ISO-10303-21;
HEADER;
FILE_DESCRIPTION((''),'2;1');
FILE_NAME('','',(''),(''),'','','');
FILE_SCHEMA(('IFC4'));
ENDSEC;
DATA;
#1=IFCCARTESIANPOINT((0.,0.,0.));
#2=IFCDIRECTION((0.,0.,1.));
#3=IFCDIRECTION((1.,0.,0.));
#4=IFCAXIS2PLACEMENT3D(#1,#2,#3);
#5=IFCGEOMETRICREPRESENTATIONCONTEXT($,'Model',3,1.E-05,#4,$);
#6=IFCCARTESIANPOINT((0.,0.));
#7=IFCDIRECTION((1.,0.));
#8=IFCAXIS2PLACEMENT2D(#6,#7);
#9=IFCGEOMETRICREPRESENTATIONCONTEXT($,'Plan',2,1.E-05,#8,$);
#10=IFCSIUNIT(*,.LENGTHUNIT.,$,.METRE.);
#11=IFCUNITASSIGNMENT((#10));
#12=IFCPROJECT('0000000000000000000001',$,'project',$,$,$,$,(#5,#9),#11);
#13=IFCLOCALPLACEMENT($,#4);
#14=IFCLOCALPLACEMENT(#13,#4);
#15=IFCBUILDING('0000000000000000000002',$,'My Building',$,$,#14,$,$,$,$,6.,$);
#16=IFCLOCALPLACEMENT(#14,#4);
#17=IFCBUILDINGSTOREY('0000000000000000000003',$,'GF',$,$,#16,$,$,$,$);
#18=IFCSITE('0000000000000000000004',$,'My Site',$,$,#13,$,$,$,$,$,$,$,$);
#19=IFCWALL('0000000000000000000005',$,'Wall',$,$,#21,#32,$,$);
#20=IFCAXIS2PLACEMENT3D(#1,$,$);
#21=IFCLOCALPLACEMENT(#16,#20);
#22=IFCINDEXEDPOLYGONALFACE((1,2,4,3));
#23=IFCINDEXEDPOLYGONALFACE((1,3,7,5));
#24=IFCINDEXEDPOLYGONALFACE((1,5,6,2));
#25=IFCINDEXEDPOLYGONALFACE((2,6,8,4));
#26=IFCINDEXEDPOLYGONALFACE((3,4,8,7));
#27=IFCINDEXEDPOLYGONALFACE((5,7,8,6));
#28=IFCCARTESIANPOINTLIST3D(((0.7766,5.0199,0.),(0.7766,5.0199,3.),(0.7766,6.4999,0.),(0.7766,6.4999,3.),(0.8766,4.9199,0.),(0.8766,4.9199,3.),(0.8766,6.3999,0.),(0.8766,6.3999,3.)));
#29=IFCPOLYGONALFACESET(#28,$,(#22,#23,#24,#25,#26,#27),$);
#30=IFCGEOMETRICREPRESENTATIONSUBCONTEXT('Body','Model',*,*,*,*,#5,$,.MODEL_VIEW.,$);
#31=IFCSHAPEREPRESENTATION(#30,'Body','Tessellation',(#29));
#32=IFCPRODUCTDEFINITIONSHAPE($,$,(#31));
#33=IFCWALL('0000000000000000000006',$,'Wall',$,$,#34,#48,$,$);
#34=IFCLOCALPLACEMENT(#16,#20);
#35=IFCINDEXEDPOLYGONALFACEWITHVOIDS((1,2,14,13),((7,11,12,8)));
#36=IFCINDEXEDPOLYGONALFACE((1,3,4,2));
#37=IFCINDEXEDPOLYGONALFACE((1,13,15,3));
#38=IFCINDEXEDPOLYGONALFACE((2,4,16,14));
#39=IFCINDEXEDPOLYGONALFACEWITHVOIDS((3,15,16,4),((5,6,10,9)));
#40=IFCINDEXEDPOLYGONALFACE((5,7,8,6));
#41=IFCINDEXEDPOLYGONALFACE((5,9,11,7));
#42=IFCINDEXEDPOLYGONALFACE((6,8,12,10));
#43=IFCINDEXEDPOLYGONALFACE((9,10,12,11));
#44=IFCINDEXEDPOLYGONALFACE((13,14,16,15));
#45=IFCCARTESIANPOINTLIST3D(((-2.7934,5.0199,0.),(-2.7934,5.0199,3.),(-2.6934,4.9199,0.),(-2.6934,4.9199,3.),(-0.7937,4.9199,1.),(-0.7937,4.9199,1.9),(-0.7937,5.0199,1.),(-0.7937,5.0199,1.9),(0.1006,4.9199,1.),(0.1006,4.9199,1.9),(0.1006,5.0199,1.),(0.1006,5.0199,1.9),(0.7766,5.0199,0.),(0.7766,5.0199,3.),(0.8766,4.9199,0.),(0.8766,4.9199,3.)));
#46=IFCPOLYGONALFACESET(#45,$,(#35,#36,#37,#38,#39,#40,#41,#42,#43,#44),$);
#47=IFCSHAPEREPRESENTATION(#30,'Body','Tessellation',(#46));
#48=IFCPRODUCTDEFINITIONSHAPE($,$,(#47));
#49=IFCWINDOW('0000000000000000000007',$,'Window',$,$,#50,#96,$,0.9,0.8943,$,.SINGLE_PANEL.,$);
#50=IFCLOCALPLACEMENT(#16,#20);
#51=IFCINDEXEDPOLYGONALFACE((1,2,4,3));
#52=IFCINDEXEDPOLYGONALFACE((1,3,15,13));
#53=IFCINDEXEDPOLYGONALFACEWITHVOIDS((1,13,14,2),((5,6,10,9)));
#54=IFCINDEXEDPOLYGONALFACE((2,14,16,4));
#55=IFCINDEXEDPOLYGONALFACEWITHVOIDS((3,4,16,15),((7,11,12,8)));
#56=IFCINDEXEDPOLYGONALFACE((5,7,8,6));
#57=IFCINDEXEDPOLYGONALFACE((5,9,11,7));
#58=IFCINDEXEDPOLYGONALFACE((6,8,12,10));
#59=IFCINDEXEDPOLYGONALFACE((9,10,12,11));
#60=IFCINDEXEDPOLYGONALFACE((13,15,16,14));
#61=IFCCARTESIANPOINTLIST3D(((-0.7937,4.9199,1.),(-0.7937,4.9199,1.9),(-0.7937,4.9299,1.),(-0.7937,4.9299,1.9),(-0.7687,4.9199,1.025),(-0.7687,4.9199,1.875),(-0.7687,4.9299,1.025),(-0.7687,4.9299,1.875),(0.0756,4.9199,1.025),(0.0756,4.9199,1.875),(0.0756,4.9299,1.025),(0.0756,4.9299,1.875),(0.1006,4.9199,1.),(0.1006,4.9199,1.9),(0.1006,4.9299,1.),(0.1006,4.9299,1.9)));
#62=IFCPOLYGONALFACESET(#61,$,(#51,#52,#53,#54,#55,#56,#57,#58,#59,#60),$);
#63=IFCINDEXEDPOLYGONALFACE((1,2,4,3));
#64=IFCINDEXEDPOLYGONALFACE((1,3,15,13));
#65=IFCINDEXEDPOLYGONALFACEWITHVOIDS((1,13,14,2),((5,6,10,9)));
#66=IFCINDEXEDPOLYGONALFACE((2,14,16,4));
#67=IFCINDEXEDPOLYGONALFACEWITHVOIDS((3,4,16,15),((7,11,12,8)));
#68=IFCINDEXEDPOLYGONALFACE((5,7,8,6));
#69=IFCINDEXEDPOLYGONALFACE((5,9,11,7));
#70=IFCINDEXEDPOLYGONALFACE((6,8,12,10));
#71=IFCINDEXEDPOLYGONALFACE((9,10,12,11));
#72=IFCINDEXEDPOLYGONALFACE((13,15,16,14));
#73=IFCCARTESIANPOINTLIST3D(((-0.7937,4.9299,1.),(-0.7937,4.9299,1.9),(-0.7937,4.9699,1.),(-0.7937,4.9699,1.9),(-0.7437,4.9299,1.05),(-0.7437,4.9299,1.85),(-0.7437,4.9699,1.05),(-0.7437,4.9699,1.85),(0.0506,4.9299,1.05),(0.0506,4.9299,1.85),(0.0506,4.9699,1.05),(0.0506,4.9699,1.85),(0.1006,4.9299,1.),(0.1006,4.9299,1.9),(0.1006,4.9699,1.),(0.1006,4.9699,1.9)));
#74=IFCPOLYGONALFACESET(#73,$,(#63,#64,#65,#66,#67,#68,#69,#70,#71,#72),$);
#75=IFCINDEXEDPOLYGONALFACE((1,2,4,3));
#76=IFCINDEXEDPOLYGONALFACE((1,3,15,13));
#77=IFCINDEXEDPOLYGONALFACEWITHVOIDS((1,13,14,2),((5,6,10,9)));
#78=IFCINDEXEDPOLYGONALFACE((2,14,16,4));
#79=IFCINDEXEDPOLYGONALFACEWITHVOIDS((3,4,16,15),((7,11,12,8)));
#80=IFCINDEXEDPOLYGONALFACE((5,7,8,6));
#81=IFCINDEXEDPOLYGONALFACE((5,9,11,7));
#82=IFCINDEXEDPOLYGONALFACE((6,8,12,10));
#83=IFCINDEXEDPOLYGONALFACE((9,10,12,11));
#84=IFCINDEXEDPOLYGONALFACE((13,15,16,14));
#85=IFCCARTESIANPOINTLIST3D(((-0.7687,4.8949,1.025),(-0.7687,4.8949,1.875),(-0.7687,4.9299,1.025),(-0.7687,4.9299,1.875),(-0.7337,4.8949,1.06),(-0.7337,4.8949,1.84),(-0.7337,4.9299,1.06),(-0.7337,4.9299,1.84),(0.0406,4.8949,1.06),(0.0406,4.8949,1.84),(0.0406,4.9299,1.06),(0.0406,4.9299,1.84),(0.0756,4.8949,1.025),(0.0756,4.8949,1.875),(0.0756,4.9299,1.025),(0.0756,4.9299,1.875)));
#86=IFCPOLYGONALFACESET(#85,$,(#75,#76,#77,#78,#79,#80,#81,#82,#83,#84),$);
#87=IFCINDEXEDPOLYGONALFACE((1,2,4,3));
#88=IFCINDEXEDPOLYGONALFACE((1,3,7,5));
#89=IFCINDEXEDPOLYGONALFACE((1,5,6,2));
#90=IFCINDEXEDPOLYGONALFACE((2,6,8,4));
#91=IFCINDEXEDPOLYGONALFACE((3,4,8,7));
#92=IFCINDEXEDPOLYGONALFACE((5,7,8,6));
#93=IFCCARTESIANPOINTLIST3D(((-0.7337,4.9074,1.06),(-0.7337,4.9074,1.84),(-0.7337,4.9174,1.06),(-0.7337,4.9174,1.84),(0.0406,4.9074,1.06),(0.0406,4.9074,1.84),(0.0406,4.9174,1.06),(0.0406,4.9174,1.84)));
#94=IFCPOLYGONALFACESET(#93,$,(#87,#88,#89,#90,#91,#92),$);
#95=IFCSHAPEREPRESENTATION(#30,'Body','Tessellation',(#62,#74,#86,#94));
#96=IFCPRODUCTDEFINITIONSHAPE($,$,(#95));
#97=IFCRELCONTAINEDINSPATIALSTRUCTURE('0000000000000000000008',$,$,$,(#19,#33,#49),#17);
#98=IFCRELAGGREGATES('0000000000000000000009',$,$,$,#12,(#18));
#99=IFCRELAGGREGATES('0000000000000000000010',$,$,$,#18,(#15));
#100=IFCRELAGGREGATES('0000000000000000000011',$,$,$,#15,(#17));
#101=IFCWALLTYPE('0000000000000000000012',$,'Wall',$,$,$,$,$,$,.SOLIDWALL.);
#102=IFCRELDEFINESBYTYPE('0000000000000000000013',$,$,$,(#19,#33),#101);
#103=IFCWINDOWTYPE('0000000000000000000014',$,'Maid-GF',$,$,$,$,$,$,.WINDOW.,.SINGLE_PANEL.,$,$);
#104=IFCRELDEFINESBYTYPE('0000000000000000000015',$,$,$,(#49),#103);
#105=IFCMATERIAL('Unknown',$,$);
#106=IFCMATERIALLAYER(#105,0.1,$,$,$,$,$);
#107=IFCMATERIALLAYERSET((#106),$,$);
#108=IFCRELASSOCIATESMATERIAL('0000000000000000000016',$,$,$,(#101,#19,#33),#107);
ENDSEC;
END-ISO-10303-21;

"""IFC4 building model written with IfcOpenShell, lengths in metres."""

from ifc_helpers import new_model, entity, si_unit, frame, origin_with_axes, origin_2d_with_axis, place, context, subcontext, project, spatial, line, indexed_curve, outline, extrude, shape, source, transform, mapped, material, layer, layer_set, layer_usage, type_object, type_shapes, element, fill, save


model = new_model("IFC4")

# Units and contexts
model_context = context("Model", 3, precision=1e-05, world=origin_with_axes())
plan_context = context("Plan", 2, precision=1e-05, world=origin_2d_with_axis())
body_context_1 = subcontext(model_context, "Body", "Model", "MODEL_VIEW")
body_context_2 = subcontext(plan_context, "Body", "Plan", "PLAN_VIEW")
ifc_project = project(units=[si_unit("LENGTHUNIT", "METRE")], contexts=[model_context, plan_context])

# Site, building, storey
site_placement = place(None, origin_with_axes())
site = spatial("IfcSite", under=ifc_project, at=site_placement, Name="My Site")
building_placement = place(site_placement, origin_with_axes())
building = spatial("IfcBuilding", under=site, at=building_placement, Name="My Building", ElevationOfTerrain=6.0)
storey_placement = place(building_placement, origin_with_axes())
storey = spatial("IfcBuildingStorey", under=building, at=storey_placement, Name="GF")

# Wall
ifc_material_1 = material(Name="Unknown")
ifc_layer = layer(ifc_material_1, 0.1)
ifc_layer_set = layer_set([ifc_layer])
wall_type = type_object("IfcWallType", Name="Wall", PredefinedType="SOLIDWALL", material=ifc_layer_set)
ifc_layer_usage_1 = layer_usage(ifc_layer_set, "AXIS2", "POSITIVE", 0.0)
wall_1_placement = place(storey_placement, frame((0.7766, 6.4999, 0.0), z_axis=(0.0, 0.0, 1.0), x_axis=(0.0, -1.0, 0.0)))
element("IfcWall", 1, at=wall_1_placement, inside=storey, type_object=wall_type, material=ifc_layer_usage_1, Name="Wall", context=body_context_1, shape_type="SweptSolid", body=[
    extrude(outline(indexed_curve([(0.0, 0.0), (0.1, 0.1), (1.58, 0.1), (1.48, 0.0)], segments=[line(1, 2, 3, 4, 1)])), origin_with_axes(), (0.0, 0.0, 1.0), 3.0),
])

# Wall, opening, window
ifc_layer_usage_2 = layer_usage(ifc_layer_set, "AXIS2", "POSITIVE", 0.0)
wall_2_placement = place(storey_placement, frame((0.7766, 5.0199, 0.0), z_axis=(0.0, 0.0, 1.0), x_axis=(-1.0, 0.0, 0.0)))
wall_2 = element("IfcWall", 2, at=wall_2_placement, inside=storey, type_object=wall_type, material=ifc_layer_usage_2, Name="Wall", context=body_context_1, shape_type="SweptSolid", body=[
    extrude(outline(indexed_curve([(0.0, 0.0), (-0.1, 0.1), (3.47, 0.1), (3.57, 0.0)], segments=[line(1, 2, 3, 4, 1)])), origin_with_axes(), (0.0, 0.0, 1.0), 3.0),
])
shared_shape_1 = source(origin_with_axes(), body_context_1, "Body", "SweptSolid", [
    extrude(outline(indexed_curve([(0.0, 0.0), (0.8943, 0.0), (0.8943, 0.9), (0.0, 0.9)], segments=[line(1, 2, 3, 4, 1)])), frame((0.0, -0.6, 0.0), z_axis=(0.0, -1.0, 0.0), x_axis=(1.0, 0.0, 0.0)), (0.0, 0.0, -1.0), 1.2),
])
opening_1_placement = place(wall_2_placement, frame((0.676, 0.0, 1.0), z_axis=(0.0, 0.0, 1.0), x_axis=(1.0, 0.0, 0.0)))
opening_1 = element("IfcOpeningElement", 3, at=opening_1_placement, cuts=wall_2, PredefinedType="OPENING", context=body_context_1, shape_type="MappedRepresentation", body=[
    mapped(shared_shape_1, transform((0.0, 0.0, 0.0), x_axis=(1.0, 0.0, 0.0), y_axis=(0.0, 1.0, 0.0), z_axis=(0.0, 0.0, 1.0), scale=1.0)),
])
window_type_1 = type_object("IfcWindowType", Name="Maid-GF", PartitioningType="SINGLE_PANEL", PredefinedType="WINDOW")
shared_shape_2 = source(origin_with_axes(), body_context_1, "Body", "SweptSolid", [
    extrude(outline(indexed_curve([(0.0, 0.0), (0.8943, 0.0), (0.8943, 0.9), (0.0, 0.9)], segments=[line(1, 2, 3, 4, 1)]), holes=[indexed_curve([(0.025, 0.025), (0.8693, 0.025), (0.8693, 0.875), (0.025, 0.875)], segments=[line(1, 2, 3, 4, 1)])]), frame((0.0, 0.09, 0.0), z_axis=(0.0, -1.0, 0.0), x_axis=(1.0, 0.0, 0.0)), (0.0, 0.0, -1.0), 0.01),
    extrude(outline(indexed_curve([(0.0, 0.0), (0.8943, 0.0), (0.8943, 0.9), (0.0, 0.9)], segments=[line(1, 2, 3, 4, 1)]), holes=[indexed_curve([(0.05, 0.05), (0.8443, 0.05), (0.8443, 0.85), (0.05, 0.85)], segments=[line(1, 2, 3, 4, 1)])]), frame((0.0, 0.05, 0.0), z_axis=(0.0, -1.0, 0.0), x_axis=(1.0, 0.0, 0.0)), (0.0, 0.0, -1.0), 0.04),
    extrude(outline(indexed_curve([(0.0, 0.0), (0.8443, 0.0), (0.8443, 0.85), (0.0, 0.85)], segments=[line(1, 2, 3, 4, 1)]), holes=[indexed_curve([(0.035, 0.035), (0.8093, 0.035), (0.8093, 0.815), (0.035, 0.815)], segments=[line(1, 2, 3, 4, 1)])]), frame((0.025, 0.09, 0.025), z_axis=(0.0, -1.0, 0.0), x_axis=(1.0, 0.0, 0.0)), (0.0, 0.0, -1.0), 0.035),
    extrude(outline(indexed_curve([(0.035, 0.035), (0.8093, 0.035), (0.8093, 0.815), (0.035, 0.815)], segments=[line(1, 2, 3, 4, 1)])), frame((0.025, 0.1025, 0.025), z_axis=(0.0, -1.0, 0.0), x_axis=(1.0, 0.0, 0.0)), (0.0, 0.0, -1.0), 0.01),
])
shared_shape_3 = source(origin_with_axes(), body_context_2, "Body", "Curve2D", [
    entity("IfcIndexedPolyCurve", entity("IfcCartesianPointList2D", [[0.05, 0.05], [0.8443, 0.05]])),
    entity("IfcIndexedPolyCurve", entity("IfcCartesianPointList2D", [[0.0, 0.1], [0.025, 0.1], [0.025, 0.09], [0.05, 0.09], [0.05, 0.05], [0.0, 0.05]]), [entity("IfcLineIndex", [1, 2, 3, 4, 5, 6, 1])]),
    entity("IfcIndexedPolyCurve", entity("IfcCartesianPointList2D", [[0.8943, 0.1], [0.8693, 0.1], [0.8693, 0.09], [0.8443, 0.09], [0.8443, 0.05], [0.8943, 0.05]]), [entity("IfcLineIndex", [1, 2, 3, 4, 5, 6, 1])]),
    entity("IfcIndexedPolyCurve", entity("IfcCartesianPointList2D", [[0.025, 0.09], [0.06, 0.09], [0.06, 0.125], [0.025, 0.125]]), [entity("IfcLineIndex", [1, 2, 3, 4, 1])]),
    entity("IfcIndexedPolyCurve", entity("IfcCartesianPointList2D", [[0.8693, 0.09], [0.8343, 0.09], [0.8343, 0.125], [0.8693, 0.125]]), [entity("IfcLineIndex", [1, 2, 3, 4, 1])]),
    entity("IfcIndexedPolyCurve", entity("IfcCartesianPointList2D", [[0.06, 0.09], [0.8343, 0.09]])),
    entity("IfcIndexedPolyCurve", entity("IfcCartesianPointList2D", [[0.06, 0.125], [0.8343, 0.125]])),
    entity("IfcIndexedPolyCurve", entity("IfcCartesianPointList2D", [[0.06, 0.1075], [0.8343, 0.1075]])),
])
type_shapes(window_type_1, [shared_shape_2, shared_shape_3])
window_1_placement = place(opening_1_placement, frame((0.0, 0.0, 0.0), z_axis=(0.0, 0.0, 1.0), x_axis=(1.0, 0.0, 0.0)))
window_1 = element("IfcWindow", 4, at=window_1_placement, inside=storey, type_object=window_type_1, Name="Window", OverallHeight=0.9, OverallWidth=0.8943, PartitioningType="SINGLE_PANEL", shapes=[
    shape(body_context_1, "Body", "MappedRepresentation", [mapped(shared_shape_2, transform((0.0, 0.0, 0.0), x_axis=(1.0, 0.0, 0.0), y_axis=(0.0, 1.0, 0.0), z_axis=(0.0, 0.0, 1.0), scale=1.0))]),
    shape(body_context_2, "Body", "MappedRepresentation", [mapped(shared_shape_3, transform((0.0, 0.0, 0.0), x_axis=(1.0, 0.0, 0.0), y_axis=(0.0, 1.0, 0.0), z_axis=(0.0, 0.0, 1.0), scale=1.0))]),
])
fill(opening_1, window_1)

save(model, "model.ifc")
